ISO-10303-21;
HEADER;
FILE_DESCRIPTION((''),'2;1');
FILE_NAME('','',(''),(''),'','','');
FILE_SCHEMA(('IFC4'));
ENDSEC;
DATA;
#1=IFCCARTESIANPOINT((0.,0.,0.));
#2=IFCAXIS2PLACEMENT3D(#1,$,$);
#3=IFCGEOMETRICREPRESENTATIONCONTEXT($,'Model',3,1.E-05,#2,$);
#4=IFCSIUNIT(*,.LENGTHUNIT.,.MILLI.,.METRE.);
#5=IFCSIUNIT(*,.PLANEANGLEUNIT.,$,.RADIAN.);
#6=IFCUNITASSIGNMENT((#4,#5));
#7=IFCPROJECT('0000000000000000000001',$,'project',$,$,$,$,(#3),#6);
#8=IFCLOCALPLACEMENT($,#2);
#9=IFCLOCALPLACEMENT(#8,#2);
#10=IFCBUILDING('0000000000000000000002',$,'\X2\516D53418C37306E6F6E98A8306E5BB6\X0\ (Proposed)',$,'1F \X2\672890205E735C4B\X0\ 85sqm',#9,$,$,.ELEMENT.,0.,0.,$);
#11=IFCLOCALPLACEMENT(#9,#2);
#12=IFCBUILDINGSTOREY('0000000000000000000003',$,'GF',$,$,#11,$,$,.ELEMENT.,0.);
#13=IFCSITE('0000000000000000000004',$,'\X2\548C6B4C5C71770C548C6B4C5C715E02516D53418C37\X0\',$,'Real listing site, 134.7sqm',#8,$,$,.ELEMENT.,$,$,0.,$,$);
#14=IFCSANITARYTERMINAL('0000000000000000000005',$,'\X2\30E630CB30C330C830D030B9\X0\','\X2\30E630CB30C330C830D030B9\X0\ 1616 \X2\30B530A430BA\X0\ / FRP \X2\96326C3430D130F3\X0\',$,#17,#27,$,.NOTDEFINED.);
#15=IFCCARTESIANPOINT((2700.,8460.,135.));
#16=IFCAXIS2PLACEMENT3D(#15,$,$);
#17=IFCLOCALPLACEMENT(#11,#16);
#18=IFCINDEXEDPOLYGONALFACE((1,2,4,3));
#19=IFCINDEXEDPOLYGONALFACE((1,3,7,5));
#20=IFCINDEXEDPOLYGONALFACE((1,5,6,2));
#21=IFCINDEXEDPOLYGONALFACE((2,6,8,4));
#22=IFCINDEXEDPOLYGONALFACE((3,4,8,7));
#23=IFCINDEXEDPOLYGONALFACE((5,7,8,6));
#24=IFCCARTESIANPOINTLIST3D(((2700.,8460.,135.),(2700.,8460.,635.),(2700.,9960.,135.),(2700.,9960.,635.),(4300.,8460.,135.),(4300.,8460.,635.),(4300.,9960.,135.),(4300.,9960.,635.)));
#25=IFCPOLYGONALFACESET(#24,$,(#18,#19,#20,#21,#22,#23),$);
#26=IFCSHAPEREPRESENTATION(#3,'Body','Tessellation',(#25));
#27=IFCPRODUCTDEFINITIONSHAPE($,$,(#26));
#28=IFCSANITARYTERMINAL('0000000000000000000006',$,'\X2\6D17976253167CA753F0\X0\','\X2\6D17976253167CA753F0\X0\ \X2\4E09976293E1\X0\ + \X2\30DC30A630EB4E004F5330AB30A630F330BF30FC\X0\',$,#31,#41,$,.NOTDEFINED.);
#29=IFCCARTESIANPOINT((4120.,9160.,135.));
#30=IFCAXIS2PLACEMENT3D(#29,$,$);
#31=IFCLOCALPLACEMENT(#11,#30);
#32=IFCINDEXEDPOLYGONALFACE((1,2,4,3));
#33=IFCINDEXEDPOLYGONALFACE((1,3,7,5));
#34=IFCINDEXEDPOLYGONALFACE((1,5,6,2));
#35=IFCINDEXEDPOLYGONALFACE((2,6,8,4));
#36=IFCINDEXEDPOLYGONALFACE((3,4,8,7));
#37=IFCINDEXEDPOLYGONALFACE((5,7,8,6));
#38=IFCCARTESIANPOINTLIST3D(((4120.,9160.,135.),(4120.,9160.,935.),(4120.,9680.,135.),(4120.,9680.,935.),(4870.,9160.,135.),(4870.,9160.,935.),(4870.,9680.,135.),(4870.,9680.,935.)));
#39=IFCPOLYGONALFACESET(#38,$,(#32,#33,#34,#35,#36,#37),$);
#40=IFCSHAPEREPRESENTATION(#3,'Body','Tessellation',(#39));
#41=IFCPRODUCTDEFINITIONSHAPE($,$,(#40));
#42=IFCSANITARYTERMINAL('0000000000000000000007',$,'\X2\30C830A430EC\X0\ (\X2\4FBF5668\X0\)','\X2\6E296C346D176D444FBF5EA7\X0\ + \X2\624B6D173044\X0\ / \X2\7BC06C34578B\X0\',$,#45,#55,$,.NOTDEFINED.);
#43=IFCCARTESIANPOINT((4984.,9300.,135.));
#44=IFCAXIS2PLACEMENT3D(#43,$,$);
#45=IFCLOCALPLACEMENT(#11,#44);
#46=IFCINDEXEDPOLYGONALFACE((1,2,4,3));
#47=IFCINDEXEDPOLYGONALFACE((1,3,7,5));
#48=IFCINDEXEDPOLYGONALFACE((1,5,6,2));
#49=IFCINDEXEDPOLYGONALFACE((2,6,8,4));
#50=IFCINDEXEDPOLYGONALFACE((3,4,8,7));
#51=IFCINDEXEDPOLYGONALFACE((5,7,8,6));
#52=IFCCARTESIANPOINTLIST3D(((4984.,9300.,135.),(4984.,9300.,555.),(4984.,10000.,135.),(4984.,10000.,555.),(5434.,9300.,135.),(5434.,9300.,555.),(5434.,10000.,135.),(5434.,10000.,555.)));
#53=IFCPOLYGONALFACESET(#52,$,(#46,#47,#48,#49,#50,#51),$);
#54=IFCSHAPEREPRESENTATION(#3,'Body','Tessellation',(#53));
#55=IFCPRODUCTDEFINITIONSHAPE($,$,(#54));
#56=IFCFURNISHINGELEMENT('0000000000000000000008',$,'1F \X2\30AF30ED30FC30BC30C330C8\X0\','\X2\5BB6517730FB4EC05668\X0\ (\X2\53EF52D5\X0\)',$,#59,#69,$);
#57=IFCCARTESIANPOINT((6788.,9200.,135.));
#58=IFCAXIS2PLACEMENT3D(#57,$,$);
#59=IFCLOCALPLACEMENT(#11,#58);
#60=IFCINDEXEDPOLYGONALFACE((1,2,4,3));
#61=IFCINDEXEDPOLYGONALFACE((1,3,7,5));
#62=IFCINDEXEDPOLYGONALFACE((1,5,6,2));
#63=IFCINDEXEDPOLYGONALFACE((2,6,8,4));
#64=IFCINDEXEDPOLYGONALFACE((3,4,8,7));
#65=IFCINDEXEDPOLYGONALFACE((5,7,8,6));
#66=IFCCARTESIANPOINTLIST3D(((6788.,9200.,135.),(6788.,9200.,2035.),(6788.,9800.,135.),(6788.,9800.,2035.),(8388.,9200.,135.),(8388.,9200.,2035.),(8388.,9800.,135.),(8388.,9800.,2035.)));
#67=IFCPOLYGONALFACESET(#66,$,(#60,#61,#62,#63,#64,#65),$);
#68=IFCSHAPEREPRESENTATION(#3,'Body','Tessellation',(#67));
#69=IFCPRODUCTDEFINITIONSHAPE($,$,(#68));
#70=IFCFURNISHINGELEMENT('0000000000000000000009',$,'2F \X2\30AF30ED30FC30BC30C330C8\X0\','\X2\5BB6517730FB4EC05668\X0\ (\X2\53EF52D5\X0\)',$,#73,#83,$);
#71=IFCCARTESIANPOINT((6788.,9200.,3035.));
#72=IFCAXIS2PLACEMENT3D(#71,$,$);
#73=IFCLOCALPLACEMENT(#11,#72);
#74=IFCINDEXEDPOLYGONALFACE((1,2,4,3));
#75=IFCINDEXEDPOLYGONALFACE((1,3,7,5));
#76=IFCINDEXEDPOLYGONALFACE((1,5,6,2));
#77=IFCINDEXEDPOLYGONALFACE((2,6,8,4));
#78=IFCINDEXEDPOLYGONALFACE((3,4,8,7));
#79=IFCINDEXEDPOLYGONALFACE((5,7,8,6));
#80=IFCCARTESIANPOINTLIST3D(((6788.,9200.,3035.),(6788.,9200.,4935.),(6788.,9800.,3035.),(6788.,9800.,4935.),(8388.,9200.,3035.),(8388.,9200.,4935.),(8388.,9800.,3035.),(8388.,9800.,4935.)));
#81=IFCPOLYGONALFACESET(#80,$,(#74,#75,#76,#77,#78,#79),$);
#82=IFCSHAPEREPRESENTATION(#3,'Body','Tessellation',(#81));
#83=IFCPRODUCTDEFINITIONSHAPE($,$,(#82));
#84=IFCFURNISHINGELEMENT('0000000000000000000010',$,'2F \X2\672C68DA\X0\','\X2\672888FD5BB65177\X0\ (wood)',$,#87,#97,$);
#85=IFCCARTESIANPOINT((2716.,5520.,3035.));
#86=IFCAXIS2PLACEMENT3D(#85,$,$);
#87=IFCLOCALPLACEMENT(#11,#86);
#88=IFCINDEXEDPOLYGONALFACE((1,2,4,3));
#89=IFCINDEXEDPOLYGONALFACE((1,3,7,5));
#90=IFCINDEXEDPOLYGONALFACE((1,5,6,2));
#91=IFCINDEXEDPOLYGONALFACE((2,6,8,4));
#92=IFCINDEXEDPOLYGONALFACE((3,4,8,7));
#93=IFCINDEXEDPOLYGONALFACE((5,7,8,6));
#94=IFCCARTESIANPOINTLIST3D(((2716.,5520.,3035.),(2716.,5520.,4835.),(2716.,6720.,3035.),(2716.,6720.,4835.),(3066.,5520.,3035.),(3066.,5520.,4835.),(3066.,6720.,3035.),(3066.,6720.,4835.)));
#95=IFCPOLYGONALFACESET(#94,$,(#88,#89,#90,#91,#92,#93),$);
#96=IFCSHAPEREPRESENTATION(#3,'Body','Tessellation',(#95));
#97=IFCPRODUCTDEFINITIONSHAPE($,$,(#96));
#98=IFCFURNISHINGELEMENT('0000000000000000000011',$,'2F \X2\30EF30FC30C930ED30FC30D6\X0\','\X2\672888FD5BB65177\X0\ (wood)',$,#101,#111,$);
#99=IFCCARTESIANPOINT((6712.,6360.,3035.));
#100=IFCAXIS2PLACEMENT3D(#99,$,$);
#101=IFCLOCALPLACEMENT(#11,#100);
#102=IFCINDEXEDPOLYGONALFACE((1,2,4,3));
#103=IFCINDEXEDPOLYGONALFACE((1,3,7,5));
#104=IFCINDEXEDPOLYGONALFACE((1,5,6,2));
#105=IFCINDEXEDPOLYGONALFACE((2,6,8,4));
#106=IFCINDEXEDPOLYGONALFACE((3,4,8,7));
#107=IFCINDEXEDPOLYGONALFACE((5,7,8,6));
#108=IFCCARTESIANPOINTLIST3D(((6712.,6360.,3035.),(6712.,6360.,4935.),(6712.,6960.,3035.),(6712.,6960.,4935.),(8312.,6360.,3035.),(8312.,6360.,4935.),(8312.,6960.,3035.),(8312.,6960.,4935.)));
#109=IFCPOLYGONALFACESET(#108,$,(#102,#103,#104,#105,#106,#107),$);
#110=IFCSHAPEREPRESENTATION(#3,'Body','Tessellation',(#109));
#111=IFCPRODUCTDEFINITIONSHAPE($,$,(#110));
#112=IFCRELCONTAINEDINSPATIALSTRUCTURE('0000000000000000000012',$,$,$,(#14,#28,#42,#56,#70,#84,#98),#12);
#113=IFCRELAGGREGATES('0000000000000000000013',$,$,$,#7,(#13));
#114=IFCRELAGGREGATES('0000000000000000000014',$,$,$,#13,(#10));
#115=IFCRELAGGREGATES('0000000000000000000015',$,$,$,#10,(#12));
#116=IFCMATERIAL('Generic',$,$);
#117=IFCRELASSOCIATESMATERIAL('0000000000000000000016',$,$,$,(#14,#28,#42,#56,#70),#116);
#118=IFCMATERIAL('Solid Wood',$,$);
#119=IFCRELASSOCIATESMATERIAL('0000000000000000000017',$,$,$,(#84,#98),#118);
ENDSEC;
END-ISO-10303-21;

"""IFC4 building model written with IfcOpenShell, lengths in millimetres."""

from ifc_helpers import new_model, si_unit, frame, frame_2d, origin, place, context, project, spatial, rectangle, extrude, material, element, save


model = new_model("IFC4")

# Units and contexts
model_context = context("Model", 3, precision=1e-05, world=origin())
ifc_project = project(units=[si_unit("LENGTHUNIT", "METRE", prefix="MILLI"), si_unit("PLANEANGLEUNIT", "RADIAN")], contexts=[model_context])

# Site, building, storey
site_placement = place(None, origin())
site = spatial("IfcSite", under=ifc_project, at=site_placement, Name="和歌山県和歌山市六十谷", ObjectType="Real listing site, 134.7sqm", CompositionType="ELEMENT", RefElevation=0.0)
building_placement = place(site_placement, origin())
building = spatial("IfcBuilding", under=site, at=building_placement, Name="六十谷の潮風の家 (Proposed)", ObjectType="1F 木造平屋 85sqm", CompositionType="ELEMENT", ElevationOfRefHeight=0.0, ElevationOfTerrain=0.0)
storey_placement = place(building_placement, origin())
storey = spatial("IfcBuildingStorey", under=building, at=storey_placement, Name="GF", CompositionType="ELEMENT", Elevation=0.0)

# Shared definitions
ifc_material_1 = material(Name="Solid Wood")

# Shared definitions
ifc_material_2 = material(Name="Generic")

# Sanitary terminals
sanitary_terminal_1_placement = place(storey_placement, frame((2700.0, 8460.0, 135.0)))
element("IfcSanitaryTerminal", 1, at=sanitary_terminal_1_placement, inside=storey, material=ifc_material_2, Name="ユニットバス", Description="ユニットバス 1616 サイズ / FRP 防水パン", PredefinedType="NOTDEFINED", context=model_context, shape_type="SweptSolid", body=[
    extrude(rectangle(XDim=1600.0, YDim=1500.0, at=frame_2d((800.0, 750.0))), frame((2700.0, 8460.0, 135.0)), (0.0, 0.0, 1.0), 500.0),
])
sanitary_terminal_2_placement = place(storey_placement, frame((4120.0, 9160.0, 135.0)))
element("IfcSanitaryTerminal", 2, at=sanitary_terminal_2_placement, inside=storey, material=ifc_material_2, Name="洗面化粧台", Description="洗面化粧台 三面鏡 + ボウル一体カウンター", PredefinedType="NOTDEFINED", context=model_context, shape_type="SweptSolid", body=[
    extrude(rectangle(XDim=750.0, YDim=520.0, at=frame_2d((375.0, 260.0))), frame((4120.0, 9160.0, 135.0)), (0.0, 0.0, 1.0), 800.0),
])
sanitary_terminal_3_placement = place(storey_placement, frame((4984.0, 9300.0, 135.0)))
element("IfcSanitaryTerminal", 3, at=sanitary_terminal_3_placement, inside=storey, material=ifc_material_2, Name="トイレ (便器)", Description="温水洗浄便座 + 手洗い / 節水型", PredefinedType="NOTDEFINED", context=model_context, shape_type="SweptSolid", body=[
    extrude(rectangle(XDim=450.0, YDim=700.0, at=frame_2d((225.0, 350.0))), frame((4984.0, 9300.0, 135.0)), (0.0, 0.0, 1.0), 420.0),
])

# Furnishing elements
furnishing_1_placement = place(storey_placement, frame((6788.0, 9200.0, 135.0)))
element("IfcFurnishingElement", 4, at=furnishing_1_placement, inside=storey, material=ifc_material_2, Name="1F クローゼット", Description="家具・什器 (可動)", context=model_context, shape_type="SweptSolid", body=[
    extrude(rectangle(XDim=1600.0, YDim=600.0, at=frame_2d((800.0, 300.0))), frame((6788.0, 9200.0, 135.0)), (0.0, 0.0, 1.0), 1900.0),
])
furnishing_2_placement = place(storey_placement, frame((6788.0, 9200.0, 3035.0)))
element("IfcFurnishingElement", 5, at=furnishing_2_placement, inside=storey, material=ifc_material_2, Name="2F クローゼット", Description="家具・什器 (可動)", context=model_context, shape_type="SweptSolid", body=[
    extrude(rectangle(XDim=1600.0, YDim=600.0, at=frame_2d((800.0, 300.0))), frame((6788.0, 9200.0, 3035.0)), (0.0, 0.0, 1.0), 1900.0),
])
furnishing_3_placement = place(storey_placement, frame((2716.0, 5520.0, 3035.0)))
element("IfcFurnishingElement", 6, at=furnishing_3_placement, inside=storey, material=ifc_material_1, Name="2F 本棚", Description="木製家具 (wood)", context=model_context, shape_type="SweptSolid", body=[
    extrude(rectangle(XDim=350.0, YDim=1200.0, at=frame_2d((175.0, 600.0))), frame((2716.0, 5520.0, 3035.0)), (0.0, 0.0, 1.0), 1800.0),
])
furnishing_4_placement = place(storey_placement, frame((6712.0, 6360.0, 3035.0)))
element("IfcFurnishingElement", 7, at=furnishing_4_placement, inside=storey, material=ifc_material_1, Name="2F ワードローブ", Description="木製家具 (wood)", context=model_context, shape_type="SweptSolid", body=[
    extrude(rectangle(XDim=1600.0, YDim=600.0, at=frame_2d((800.0, 300.0))), frame((6712.0, 6360.0, 3035.0)), (0.0, 0.0, 1.0), 1900.0),
])

save(model, "model.ifc")
